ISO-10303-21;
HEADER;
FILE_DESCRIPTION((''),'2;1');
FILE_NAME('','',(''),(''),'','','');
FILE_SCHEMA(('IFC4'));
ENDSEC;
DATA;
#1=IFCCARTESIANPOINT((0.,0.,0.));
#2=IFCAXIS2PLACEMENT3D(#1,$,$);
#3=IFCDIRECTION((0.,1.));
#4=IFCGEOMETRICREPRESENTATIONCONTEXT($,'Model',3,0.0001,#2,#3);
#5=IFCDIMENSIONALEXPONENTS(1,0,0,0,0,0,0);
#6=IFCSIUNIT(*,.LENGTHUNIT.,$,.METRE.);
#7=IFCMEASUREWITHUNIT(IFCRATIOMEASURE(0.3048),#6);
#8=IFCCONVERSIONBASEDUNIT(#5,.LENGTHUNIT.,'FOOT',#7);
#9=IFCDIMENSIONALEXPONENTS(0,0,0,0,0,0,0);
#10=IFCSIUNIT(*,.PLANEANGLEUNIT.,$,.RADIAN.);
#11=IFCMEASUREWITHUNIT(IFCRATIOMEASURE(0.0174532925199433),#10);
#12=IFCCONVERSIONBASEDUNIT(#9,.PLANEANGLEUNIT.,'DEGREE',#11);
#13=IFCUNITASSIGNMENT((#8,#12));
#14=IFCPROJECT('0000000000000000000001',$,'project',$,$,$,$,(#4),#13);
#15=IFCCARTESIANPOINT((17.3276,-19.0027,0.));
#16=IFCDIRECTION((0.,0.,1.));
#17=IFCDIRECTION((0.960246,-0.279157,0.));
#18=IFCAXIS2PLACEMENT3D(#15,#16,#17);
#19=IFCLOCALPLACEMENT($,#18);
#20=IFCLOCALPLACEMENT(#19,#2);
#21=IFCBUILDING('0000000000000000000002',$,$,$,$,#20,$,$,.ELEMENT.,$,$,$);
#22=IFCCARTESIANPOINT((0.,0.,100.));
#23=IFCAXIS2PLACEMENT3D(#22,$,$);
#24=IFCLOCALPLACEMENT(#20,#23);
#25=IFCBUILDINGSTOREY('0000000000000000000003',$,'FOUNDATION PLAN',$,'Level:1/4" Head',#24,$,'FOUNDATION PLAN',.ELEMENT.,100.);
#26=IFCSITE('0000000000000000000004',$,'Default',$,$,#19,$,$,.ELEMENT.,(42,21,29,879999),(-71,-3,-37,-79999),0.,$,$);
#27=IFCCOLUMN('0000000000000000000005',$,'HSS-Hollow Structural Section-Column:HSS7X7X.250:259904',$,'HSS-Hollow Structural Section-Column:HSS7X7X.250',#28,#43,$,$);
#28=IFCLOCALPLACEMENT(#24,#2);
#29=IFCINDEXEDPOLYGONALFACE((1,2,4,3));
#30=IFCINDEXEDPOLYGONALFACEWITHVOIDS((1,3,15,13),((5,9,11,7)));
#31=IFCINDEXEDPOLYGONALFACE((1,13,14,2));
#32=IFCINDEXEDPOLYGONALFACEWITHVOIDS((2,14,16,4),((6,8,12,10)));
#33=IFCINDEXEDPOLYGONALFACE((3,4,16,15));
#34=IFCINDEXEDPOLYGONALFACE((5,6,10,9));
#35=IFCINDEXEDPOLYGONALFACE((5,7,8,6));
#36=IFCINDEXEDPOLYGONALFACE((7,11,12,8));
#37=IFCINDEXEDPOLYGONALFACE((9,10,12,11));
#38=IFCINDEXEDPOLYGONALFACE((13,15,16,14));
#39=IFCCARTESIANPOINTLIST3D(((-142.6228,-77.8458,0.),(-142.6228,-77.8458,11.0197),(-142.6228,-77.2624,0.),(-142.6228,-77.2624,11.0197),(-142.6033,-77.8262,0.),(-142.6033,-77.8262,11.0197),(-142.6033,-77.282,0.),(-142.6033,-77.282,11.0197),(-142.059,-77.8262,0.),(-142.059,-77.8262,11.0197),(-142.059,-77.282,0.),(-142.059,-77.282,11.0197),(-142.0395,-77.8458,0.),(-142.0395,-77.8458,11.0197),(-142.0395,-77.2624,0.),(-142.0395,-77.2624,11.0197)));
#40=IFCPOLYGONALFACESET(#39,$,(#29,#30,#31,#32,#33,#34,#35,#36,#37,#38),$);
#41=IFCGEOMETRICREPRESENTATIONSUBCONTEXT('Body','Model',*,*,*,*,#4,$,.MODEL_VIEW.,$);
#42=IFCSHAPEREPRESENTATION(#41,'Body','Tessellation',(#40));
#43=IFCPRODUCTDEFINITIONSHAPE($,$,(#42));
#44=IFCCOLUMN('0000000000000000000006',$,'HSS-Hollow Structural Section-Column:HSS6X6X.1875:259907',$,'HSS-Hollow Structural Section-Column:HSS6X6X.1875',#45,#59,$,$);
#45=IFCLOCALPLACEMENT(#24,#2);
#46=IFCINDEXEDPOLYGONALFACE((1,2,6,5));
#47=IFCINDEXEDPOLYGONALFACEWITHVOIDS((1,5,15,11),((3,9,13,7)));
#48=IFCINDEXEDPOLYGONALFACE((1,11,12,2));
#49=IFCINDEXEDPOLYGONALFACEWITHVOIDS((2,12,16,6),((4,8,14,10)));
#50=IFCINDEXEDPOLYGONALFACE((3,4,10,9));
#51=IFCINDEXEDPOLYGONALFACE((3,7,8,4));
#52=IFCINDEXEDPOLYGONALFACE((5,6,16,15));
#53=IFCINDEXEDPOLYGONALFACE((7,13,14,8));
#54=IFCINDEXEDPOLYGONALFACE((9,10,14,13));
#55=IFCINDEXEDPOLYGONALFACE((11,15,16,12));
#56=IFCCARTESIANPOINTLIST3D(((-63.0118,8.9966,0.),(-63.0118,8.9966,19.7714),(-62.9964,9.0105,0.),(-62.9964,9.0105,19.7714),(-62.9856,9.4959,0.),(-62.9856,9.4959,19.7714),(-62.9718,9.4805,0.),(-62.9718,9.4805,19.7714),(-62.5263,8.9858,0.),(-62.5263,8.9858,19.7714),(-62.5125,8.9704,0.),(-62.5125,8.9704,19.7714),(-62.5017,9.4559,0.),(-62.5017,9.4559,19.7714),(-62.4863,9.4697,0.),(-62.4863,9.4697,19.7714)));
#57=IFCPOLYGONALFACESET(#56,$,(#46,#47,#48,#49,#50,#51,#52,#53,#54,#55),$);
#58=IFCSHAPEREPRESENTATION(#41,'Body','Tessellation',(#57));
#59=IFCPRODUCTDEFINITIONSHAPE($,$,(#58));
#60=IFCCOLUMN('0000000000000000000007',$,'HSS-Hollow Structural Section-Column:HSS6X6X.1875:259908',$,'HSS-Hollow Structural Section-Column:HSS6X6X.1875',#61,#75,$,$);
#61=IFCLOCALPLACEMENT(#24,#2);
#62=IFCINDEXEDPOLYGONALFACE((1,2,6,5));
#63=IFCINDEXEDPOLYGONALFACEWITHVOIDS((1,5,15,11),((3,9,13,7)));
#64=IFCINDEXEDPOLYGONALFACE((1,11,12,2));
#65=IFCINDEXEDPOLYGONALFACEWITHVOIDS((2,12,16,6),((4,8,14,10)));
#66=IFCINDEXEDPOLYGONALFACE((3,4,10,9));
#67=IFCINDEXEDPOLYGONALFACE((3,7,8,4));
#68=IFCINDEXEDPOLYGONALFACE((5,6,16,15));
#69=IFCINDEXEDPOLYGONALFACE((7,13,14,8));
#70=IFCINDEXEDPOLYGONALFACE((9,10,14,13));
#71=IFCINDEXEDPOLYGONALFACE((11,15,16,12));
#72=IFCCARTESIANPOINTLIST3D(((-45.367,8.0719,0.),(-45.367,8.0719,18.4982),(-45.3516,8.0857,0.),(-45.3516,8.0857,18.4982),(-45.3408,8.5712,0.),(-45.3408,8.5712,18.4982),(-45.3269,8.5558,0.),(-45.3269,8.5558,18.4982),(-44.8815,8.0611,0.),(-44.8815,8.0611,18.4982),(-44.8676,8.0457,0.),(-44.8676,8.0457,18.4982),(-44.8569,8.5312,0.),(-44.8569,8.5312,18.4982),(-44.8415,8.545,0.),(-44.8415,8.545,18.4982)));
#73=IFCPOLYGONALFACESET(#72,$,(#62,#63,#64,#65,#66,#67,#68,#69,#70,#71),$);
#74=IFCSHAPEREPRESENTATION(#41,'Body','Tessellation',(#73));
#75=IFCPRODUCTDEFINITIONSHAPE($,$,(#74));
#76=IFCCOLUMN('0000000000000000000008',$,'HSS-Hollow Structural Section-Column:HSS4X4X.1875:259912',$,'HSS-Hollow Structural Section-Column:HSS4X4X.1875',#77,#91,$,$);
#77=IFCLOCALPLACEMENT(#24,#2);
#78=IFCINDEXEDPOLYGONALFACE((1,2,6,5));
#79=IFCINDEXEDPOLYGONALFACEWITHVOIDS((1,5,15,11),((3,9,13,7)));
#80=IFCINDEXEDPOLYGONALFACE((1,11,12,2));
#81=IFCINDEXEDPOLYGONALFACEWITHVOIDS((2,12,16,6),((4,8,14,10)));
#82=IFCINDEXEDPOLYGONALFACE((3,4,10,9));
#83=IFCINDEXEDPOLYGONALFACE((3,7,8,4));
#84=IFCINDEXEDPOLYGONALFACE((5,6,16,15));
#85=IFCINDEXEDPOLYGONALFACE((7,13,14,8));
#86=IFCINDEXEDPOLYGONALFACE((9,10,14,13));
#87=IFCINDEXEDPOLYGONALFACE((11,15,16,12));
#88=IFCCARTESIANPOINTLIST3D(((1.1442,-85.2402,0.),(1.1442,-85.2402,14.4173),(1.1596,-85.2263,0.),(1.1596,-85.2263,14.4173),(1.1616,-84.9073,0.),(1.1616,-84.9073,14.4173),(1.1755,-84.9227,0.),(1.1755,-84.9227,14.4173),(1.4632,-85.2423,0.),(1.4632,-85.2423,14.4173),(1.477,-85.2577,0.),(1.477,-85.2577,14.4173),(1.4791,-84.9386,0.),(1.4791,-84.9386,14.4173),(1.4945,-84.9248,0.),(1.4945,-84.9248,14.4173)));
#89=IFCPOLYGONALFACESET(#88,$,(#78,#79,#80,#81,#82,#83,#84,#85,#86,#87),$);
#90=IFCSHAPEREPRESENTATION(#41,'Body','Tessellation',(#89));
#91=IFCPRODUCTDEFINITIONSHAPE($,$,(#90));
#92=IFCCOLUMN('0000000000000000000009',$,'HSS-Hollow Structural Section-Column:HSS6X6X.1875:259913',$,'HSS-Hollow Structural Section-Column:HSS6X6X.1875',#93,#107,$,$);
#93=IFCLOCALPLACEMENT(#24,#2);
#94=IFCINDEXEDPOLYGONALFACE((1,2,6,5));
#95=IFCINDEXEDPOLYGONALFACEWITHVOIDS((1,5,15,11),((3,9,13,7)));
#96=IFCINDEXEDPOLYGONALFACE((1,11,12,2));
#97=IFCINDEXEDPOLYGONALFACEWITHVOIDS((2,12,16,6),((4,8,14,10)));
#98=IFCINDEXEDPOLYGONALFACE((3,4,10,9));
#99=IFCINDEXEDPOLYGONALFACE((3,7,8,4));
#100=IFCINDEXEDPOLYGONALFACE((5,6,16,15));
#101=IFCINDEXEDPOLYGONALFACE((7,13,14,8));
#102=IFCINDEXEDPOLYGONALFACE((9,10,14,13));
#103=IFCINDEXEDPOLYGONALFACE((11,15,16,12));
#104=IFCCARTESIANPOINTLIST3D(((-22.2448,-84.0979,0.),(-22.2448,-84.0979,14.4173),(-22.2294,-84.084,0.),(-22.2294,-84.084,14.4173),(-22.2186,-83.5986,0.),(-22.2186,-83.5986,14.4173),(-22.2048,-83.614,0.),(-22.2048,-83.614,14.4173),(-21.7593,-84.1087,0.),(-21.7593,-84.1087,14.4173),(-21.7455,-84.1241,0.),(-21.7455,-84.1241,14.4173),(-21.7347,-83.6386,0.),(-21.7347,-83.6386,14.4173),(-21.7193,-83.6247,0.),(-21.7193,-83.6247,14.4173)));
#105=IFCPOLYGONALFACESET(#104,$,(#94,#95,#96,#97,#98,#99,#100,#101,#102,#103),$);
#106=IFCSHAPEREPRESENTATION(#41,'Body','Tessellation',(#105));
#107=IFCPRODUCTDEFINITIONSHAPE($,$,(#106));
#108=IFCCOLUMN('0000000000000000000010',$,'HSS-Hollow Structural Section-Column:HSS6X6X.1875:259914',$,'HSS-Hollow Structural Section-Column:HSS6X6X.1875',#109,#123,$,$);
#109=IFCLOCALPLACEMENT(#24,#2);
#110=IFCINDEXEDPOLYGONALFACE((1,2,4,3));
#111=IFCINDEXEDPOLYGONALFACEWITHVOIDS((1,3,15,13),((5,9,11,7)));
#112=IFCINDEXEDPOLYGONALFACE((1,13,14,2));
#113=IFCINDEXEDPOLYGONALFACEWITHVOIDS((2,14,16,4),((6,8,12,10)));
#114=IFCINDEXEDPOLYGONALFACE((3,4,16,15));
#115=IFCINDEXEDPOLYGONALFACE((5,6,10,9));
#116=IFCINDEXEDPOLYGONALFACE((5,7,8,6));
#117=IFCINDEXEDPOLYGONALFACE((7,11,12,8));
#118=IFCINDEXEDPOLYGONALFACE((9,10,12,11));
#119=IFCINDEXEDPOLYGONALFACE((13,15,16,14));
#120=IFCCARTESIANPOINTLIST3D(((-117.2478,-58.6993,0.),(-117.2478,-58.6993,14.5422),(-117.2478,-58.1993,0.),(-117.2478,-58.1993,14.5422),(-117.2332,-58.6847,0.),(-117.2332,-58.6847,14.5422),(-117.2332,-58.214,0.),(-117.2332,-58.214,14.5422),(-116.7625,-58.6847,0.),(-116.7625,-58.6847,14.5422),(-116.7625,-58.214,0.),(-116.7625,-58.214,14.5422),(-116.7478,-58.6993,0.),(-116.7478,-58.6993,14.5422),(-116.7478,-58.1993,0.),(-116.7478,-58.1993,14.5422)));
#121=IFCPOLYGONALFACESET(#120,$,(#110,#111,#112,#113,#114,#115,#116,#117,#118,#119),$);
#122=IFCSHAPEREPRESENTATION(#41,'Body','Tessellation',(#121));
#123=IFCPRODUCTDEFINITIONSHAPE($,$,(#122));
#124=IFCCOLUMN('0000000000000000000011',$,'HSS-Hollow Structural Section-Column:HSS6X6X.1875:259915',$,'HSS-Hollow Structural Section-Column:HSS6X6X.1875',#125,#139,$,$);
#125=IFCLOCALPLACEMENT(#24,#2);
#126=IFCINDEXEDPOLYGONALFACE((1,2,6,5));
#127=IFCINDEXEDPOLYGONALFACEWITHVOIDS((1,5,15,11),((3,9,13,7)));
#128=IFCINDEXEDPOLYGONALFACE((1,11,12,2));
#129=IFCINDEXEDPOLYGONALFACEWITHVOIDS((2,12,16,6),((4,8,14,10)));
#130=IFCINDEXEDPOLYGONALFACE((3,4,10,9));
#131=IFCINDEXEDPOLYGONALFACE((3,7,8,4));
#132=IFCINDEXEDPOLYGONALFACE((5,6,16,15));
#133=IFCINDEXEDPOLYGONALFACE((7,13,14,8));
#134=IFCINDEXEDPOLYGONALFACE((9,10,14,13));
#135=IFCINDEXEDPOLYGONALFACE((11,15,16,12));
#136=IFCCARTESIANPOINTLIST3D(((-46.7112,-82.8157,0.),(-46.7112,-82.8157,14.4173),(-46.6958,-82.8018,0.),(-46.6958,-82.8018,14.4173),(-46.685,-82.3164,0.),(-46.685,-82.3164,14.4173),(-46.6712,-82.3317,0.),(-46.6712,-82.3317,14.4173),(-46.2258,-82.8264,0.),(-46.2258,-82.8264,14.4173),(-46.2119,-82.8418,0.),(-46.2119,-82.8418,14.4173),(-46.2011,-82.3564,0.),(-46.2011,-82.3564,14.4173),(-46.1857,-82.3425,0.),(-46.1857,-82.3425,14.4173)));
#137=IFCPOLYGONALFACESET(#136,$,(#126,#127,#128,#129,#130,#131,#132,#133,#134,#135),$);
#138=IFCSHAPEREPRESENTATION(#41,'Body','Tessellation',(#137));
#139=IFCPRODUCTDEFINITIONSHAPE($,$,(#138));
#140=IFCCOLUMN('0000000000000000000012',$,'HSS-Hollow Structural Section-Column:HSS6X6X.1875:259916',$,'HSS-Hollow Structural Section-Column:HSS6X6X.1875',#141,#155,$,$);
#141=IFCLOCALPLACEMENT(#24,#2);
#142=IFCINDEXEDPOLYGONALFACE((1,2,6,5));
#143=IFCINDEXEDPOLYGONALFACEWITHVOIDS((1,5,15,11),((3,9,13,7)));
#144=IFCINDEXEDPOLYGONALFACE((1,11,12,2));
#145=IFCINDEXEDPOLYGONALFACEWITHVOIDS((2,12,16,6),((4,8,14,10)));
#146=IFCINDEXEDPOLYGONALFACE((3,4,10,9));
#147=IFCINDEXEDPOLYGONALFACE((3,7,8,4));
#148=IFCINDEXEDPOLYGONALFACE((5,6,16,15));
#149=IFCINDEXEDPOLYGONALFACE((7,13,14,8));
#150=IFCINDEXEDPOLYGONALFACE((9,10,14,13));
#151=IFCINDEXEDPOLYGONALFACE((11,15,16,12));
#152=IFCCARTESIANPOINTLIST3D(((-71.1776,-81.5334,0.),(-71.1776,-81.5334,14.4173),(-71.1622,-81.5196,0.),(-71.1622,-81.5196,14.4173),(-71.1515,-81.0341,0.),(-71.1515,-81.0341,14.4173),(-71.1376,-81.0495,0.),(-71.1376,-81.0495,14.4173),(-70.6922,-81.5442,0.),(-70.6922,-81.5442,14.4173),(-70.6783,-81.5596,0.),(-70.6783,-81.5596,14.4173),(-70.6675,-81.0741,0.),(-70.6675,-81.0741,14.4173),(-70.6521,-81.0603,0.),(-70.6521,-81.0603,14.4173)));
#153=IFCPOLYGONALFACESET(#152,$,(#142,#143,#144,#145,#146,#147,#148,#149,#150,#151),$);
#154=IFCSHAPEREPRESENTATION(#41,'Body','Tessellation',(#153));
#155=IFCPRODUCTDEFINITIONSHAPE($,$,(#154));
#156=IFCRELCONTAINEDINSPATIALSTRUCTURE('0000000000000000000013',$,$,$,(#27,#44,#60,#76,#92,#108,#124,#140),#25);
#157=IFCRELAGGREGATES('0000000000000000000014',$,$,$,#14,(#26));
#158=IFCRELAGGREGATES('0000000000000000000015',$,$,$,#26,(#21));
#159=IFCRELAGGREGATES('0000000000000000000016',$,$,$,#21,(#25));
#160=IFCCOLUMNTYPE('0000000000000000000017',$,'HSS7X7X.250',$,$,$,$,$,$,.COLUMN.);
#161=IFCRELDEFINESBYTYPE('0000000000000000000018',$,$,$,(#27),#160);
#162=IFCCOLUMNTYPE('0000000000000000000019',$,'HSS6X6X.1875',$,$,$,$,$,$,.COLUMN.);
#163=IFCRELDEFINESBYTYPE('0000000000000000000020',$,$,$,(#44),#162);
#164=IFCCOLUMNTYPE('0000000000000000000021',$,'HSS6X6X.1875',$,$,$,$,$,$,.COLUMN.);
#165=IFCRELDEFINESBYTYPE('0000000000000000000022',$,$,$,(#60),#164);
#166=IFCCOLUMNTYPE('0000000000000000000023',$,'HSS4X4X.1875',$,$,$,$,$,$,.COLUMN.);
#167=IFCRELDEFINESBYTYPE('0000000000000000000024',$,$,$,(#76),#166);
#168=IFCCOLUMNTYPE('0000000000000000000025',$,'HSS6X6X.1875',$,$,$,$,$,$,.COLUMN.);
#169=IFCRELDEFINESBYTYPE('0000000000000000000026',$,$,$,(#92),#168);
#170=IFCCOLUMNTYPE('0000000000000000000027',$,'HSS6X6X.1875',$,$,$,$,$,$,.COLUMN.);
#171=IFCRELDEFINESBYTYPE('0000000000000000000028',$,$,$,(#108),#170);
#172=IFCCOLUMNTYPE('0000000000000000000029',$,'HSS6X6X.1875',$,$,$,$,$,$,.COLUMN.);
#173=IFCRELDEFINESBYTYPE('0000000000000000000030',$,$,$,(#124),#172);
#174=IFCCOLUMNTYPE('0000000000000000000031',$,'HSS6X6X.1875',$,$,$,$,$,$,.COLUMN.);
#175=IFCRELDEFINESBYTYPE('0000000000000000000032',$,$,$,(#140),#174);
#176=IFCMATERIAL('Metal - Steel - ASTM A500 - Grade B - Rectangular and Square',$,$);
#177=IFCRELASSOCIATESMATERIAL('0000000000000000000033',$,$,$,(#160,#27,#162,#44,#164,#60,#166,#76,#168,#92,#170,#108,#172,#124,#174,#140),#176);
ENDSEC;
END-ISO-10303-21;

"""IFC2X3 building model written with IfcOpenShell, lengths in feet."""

from ifc_helpers import new_model, entity, si_unit, converted_unit, direction, frame, frame_2d, origin, origin_2d_with_axis, place, context, subcontext, project, spatial, rectangle, extrude, boolean, source, transform, mapped, material, type_object, type_shapes, element, save


model = new_model("IFC2X3")

# Units and contexts
model_context = context("Model", 3, precision=0.0001, world=origin(), true_north=direction((0.0, 1.0)))
body_context = subcontext(model_context, "Body", "Model", "MODEL_VIEW")
ifc_project = project(units=[converted_unit("LENGTHUNIT", "FOOT", entity("IfcRatioMeasure", 0.3048), si_unit("LENGTHUNIT", "METRE"), dimensions=[1, 0, 0, 0, 0, 0, 0]), converted_unit("PLANEANGLEUNIT", "DEGREE", entity("IfcRatioMeasure", 0.0174532925199433), si_unit("PLANEANGLEUNIT", "RADIAN"), dimensions=[0, 0, 0, 0, 0, 0, 0])], contexts=[model_context])

# Site, building, storey
site_placement = place(None, frame((17.3276, -19.0027, 0.0), z_axis=(0.0, 0.0, 1.0), x_axis=(0.960246, -0.279157, 0.0)))
site = spatial("IfcSite", under=ifc_project, at=site_placement, Name="Default", CompositionType="ELEMENT", RefLatitude=(42, 21, 29, 879999), RefLongitude=(-71, -3, -37, -79999), RefElevation=0.0)
building_placement = place(site_placement, origin())
building = spatial("IfcBuilding", under=site, at=building_placement, CompositionType="ELEMENT")
storey_placement = place(building_placement, frame((0.0, 0.0, 100.0)))
storey = spatial("IfcBuildingStorey", under=building, at=storey_placement, Name="FOUNDATION PLAN", ObjectType="Level:1/4\" Head", LongName="FOUNDATION PLAN", CompositionType="ELEMENT", Elevation=100.0)

# Columns
ifc_material_1 = material(Name="Metal - Steel - ASTM A500 - Grade B - Rectangular and Square")
column_type_1 = type_object("IfcColumnType", Name="HSS7X7X.250", PredefinedType="COLUMN", material=ifc_material_1)
shared_shape_1 = source(origin(), body_context, "Body", "SweptSolid", [
    boolean("DIFFERENCE", extrude(rectangle(XDim=0.5833, YDim=0.5833, at=origin_2d_with_axis()), frame((-142.3312, -77.5541, 100.0), z_axis=(0.0, 0.0, 1.0), x_axis=(0.0, -1.0, 0.0)), (0.0, 0.0, 1.0), 11.0197), extrude(rectangle(XDim=0.5443, YDim=0.5443, at=frame_2d((0.0, 0.0), x_axis=(1.0, 0.0))), frame((-142.3312, -77.5541, 111.0197), z_axis=(0.0, 0.0, -1.0), x_axis=(0.0, -1.0, 0.0)), (0.0, 0.0, 1.0), 11.0197)),
])
type_shapes(column_type_1, [shared_shape_1])
column_1_placement = place(storey_placement, frame((0.0, 0.0, -100.0)))
element("IfcColumn", 1, at=column_1_placement, inside=storey, type_object=column_type_1, material=ifc_material_1, Name="HSS-Hollow Structural Section-Column:HSS7X7X.250:259904", ObjectType="HSS-Hollow Structural Section-Column:HSS7X7X.250", context=body_context, shape_type="MappedRepresentation", body=[
    mapped(shared_shape_1, transform((0.0, 0.0, 0.0), scale=1.0)),
])
column_type_2 = type_object("IfcColumnType", Name="HSS6X6X.1875", PredefinedType="COLUMN", material=ifc_material_1)
shared_shape_2 = source(origin(), body_context, "Body", "SweptSolid", [
    boolean("DIFFERENCE", extrude(rectangle(XDim=0.5, YDim=0.5, at=origin_2d_with_axis()), frame((-62.7491, 9.2332, 100.0), z_axis=(0.0, 0.0, 1.0), x_axis=(-0.99863, 0.052336, 0.0)), (0.0, 0.0, 1.0), 19.7714), extrude(rectangle(XDim=0.4707, YDim=0.4707, at=frame_2d((0.0, 0.0), x_axis=(1.0, 0.0))), frame((-62.7491, 9.2332, 119.7714), z_axis=(0.0, 0.0, -1.0), x_axis=(-0.052336, -0.99863, 0.0)), (0.0, 0.0, 1.0), 19.7714)),
])
type_shapes(column_type_2, [shared_shape_2])
column_2_placement = place(storey_placement, frame((0.0, 0.0, -100.0)))
element("IfcColumn", 2, at=column_2_placement, inside=storey, type_object=column_type_2, material=ifc_material_1, Name="HSS-Hollow Structural Section-Column:HSS6X6X.1875:259907", ObjectType="HSS-Hollow Structural Section-Column:HSS6X6X.1875", context=body_context, shape_type="MappedRepresentation", body=[
    mapped(shared_shape_2, transform((0.0, 0.0, 0.0), scale=1.0)),
])
column_type_3 = type_object("IfcColumnType", Name="HSS6X6X.1875", PredefinedType="COLUMN", material=ifc_material_1)
shared_shape_3 = source(origin(), body_context, "Body", "SweptSolid", [
    boolean("DIFFERENCE", extrude(rectangle(XDim=0.5, YDim=0.5, at=frame_2d((0.0, 0.0), x_axis=(1.0, 0.0))), frame((-45.1042, 8.3084, 100.0), z_axis=(0.0, 0.0, 1.0), x_axis=(0.052336, 0.99863, 0.0)), (0.0, 0.0, 1.0), 18.4982), extrude(rectangle(XDim=0.4707, YDim=0.4707, at=frame_2d((0.0, 0.0), x_axis=(1.0, 0.0))), frame((-45.1042, 8.3084, 118.4982), z_axis=(0.0, 0.0, -1.0), x_axis=(-0.052336, -0.99863, 0.0)), (0.0, 0.0, 1.0), 18.4982)),
])
type_shapes(column_type_3, [shared_shape_3])
column_3_placement = place(storey_placement, frame((0.0, 0.0, -100.0)))
element("IfcColumn", 3, at=column_3_placement, inside=storey, type_object=column_type_3, material=ifc_material_1, Name="HSS-Hollow Structural Section-Column:HSS6X6X.1875:259908", ObjectType="HSS-Hollow Structural Section-Column:HSS6X6X.1875", context=body_context, shape_type="MappedRepresentation", body=[
    mapped(shared_shape_3, transform((0.0, 0.0, 0.0), scale=1.0)),
])
column_type_4 = type_object("IfcColumnType", Name="HSS4X4X.1875", PredefinedType="COLUMN", material=ifc_material_1)
shared_shape_4 = source(origin(), body_context, "Body", "SweptSolid", [
    boolean("DIFFERENCE", extrude(rectangle(XDim=0.3333, YDim=0.3333, at=frame_2d((0.0, 0.0), x_axis=(1.0, 0.0))), frame((0.0, 0.0, 100.0), z_axis=(0.0, 0.0, 1.0), x_axis=(0.0, -1.0, 0.0)), (0.0, 0.0, 1.0), 14.4173), extrude(rectangle(XDim=0.304, YDim=0.304, at=frame_2d((0.0, 0.0), x_axis=(1.0, 0.0))), frame((0.0, 0.0, 114.4173), z_axis=(0.0, 0.0, -1.0), x_axis=(0.0, -1.0, 0.0)), (0.0, 0.0, 1.0), 14.4173)),
])
type_shapes(column_type_4, [shared_shape_4])
column_4_placement = place(storey_placement, frame((1.3193, -85.0825, -100.0), z_axis=(0.0, 0.0, 1.0), x_axis=(0.99863, -0.052336, 0.0)))
element("IfcColumn", 4, at=column_4_placement, inside=storey, type_object=column_type_4, material=ifc_material_1, Name="HSS-Hollow Structural Section-Column:HSS4X4X.1875:259912", ObjectType="HSS-Hollow Structural Section-Column:HSS4X4X.1875", context=body_context, shape_type="MappedRepresentation", body=[
    mapped(shared_shape_4, transform((0.0, 0.0, 0.0), scale=1.0)),
])
column_type_5 = type_object("IfcColumnType", Name="HSS6X6X.1875", PredefinedType="COLUMN", material=ifc_material_1)
shared_shape_5 = source(origin(), body_context, "Body", "SweptSolid", [
    boolean("DIFFERENCE", extrude(rectangle(XDim=0.5, YDim=0.5, at=origin_2d_with_axis()), frame((0.0, 0.0, 100.0), z_axis=(0.0, 0.0, 1.0), x_axis=(0.0, -1.0, 0.0)), (0.0, 0.0, 1.0), 14.4173), extrude(rectangle(XDim=0.4707, YDim=0.4707, at=origin_2d_with_axis()), frame((0.0, 0.0, 114.4173), z_axis=(0.0, 0.0, -1.0), x_axis=(0.0, -1.0, 0.0)), (0.0, 0.0, 1.0), 14.4173)),
])
type_shapes(column_type_5, [shared_shape_5])
column_5_placement = place(storey_placement, frame((-21.982, -83.8613, -100.0), z_axis=(0.0, 0.0, 1.0), x_axis=(0.99863, -0.052336, 0.0)))
element("IfcColumn", 5, at=column_5_placement, inside=storey, type_object=column_type_5, material=ifc_material_1, Name="HSS-Hollow Structural Section-Column:HSS6X6X.1875:259913", ObjectType="HSS-Hollow Structural Section-Column:HSS6X6X.1875", context=body_context, shape_type="MappedRepresentation", body=[
    mapped(shared_shape_5, transform((0.0, 0.0, 0.0), scale=1.0)),
])
column_type_6 = type_object("IfcColumnType", Name="HSS6X6X.1875", PredefinedType="COLUMN", material=ifc_material_1)
shared_shape_6 = source(origin(), body_context, "Body", "SweptSolid", [
    boolean("DIFFERENCE", extrude(rectangle(XDim=0.5, YDim=0.5, at=origin_2d_with_axis()), frame((-116.9978, -58.4493, 100.0), z_axis=(0.0, 0.0, 1.0), x_axis=(0.0, -1.0, 0.0)), (0.0, 0.0, 1.0), 14.5422), extrude(rectangle(XDim=0.4707, YDim=0.4707, at=origin_2d_with_axis()), frame((-116.9978, -58.4493, 114.5422), z_axis=(0.0, 0.0, -1.0), x_axis=(0.0, -1.0, 0.0)), (0.0, 0.0, 1.0), 14.5422)),
])
type_shapes(column_type_6, [shared_shape_6])
column_6_placement = place(storey_placement, frame((0.0, 0.0, -100.0)))
element("IfcColumn", 6, at=column_6_placement, inside=storey, type_object=column_type_6, material=ifc_material_1, Name="HSS-Hollow Structural Section-Column:HSS6X6X.1875:259914", ObjectType="HSS-Hollow Structural Section-Column:HSS6X6X.1875", context=body_context, shape_type="MappedRepresentation", body=[
    mapped(shared_shape_6, transform((0.0, 0.0, 0.0), scale=1.0)),
])
column_type_7 = type_object("IfcColumnType", Name="HSS6X6X.1875", PredefinedType="COLUMN", material=ifc_material_1)
shared_shape_7 = source(origin(), body_context, "Body", "SweptSolid", [
    boolean("DIFFERENCE", extrude(rectangle(XDim=0.5, YDim=0.5, at=origin_2d_with_axis()), frame((-46.4485, -82.5791, 100.0), z_axis=(0.0, 0.0, 1.0), x_axis=(-0.99863, 0.052336, 0.0)), (0.0, 0.0, 1.0), 14.4173), extrude(rectangle(XDim=0.4707, YDim=0.4707, at=frame_2d((0.0, 0.0), x_axis=(1.0, 0.0))), frame((-46.4485, -82.5791, 114.4173), z_axis=(0.0, 0.0, -1.0), x_axis=(-0.052336, -0.99863, 0.0)), (0.0, 0.0, 1.0), 14.4173)),
])
type_shapes(column_type_7, [shared_shape_7])
column_7_placement = place(storey_placement, frame((0.0, 0.0, -100.0)))
element("IfcColumn", 7, at=column_7_placement, inside=storey, type_object=column_type_7, material=ifc_material_1, Name="HSS-Hollow Structural Section-Column:HSS6X6X.1875:259915", ObjectType="HSS-Hollow Structural Section-Column:HSS6X6X.1875", context=body_context, shape_type="MappedRepresentation", body=[
    mapped(shared_shape_7, transform((0.0, 0.0, 0.0), scale=1.0)),
])
column_type_8 = type_object("IfcColumnType", Name="HSS6X6X.1875", PredefinedType="COLUMN", material=ifc_material_1)
shared_shape_8 = source(origin(), body_context, "Body", "SweptSolid", [
    boolean("DIFFERENCE", extrude(rectangle(XDim=0.5, YDim=0.5, at=origin_2d_with_axis()), frame((-70.9149, -81.2969, 100.0), z_axis=(0.0, 0.0, 1.0), x_axis=(-0.99863, 0.052336, 0.0)), (0.0, 0.0, 1.0), 14.4173), extrude(rectangle(XDim=0.4707, YDim=0.4707, at=frame_2d((0.0, 0.0), x_axis=(1.0, 0.0))), frame((-70.9149, -81.2969, 114.4173), z_axis=(0.0, 0.0, -1.0), x_axis=(-0.052336, -0.99863, 0.0)), (0.0, 0.0, 1.0), 14.4173)),
])
type_shapes(column_type_8, [shared_shape_8])
column_8_placement = place(storey_placement, frame((0.0, 0.0, -100.0)))
element("IfcColumn", 8, at=column_8_placement, inside=storey, type_object=column_type_8, material=ifc_material_1, Name="HSS-Hollow Structural Section-Column:HSS6X6X.1875:259916", ObjectType="HSS-Hollow Structural Section-Column:HSS6X6X.1875", context=body_context, shape_type="MappedRepresentation", body=[
    mapped(shared_shape_8, transform((0.0, 0.0, 0.0), scale=1.0)),
])

save(model, "model.ifc")
